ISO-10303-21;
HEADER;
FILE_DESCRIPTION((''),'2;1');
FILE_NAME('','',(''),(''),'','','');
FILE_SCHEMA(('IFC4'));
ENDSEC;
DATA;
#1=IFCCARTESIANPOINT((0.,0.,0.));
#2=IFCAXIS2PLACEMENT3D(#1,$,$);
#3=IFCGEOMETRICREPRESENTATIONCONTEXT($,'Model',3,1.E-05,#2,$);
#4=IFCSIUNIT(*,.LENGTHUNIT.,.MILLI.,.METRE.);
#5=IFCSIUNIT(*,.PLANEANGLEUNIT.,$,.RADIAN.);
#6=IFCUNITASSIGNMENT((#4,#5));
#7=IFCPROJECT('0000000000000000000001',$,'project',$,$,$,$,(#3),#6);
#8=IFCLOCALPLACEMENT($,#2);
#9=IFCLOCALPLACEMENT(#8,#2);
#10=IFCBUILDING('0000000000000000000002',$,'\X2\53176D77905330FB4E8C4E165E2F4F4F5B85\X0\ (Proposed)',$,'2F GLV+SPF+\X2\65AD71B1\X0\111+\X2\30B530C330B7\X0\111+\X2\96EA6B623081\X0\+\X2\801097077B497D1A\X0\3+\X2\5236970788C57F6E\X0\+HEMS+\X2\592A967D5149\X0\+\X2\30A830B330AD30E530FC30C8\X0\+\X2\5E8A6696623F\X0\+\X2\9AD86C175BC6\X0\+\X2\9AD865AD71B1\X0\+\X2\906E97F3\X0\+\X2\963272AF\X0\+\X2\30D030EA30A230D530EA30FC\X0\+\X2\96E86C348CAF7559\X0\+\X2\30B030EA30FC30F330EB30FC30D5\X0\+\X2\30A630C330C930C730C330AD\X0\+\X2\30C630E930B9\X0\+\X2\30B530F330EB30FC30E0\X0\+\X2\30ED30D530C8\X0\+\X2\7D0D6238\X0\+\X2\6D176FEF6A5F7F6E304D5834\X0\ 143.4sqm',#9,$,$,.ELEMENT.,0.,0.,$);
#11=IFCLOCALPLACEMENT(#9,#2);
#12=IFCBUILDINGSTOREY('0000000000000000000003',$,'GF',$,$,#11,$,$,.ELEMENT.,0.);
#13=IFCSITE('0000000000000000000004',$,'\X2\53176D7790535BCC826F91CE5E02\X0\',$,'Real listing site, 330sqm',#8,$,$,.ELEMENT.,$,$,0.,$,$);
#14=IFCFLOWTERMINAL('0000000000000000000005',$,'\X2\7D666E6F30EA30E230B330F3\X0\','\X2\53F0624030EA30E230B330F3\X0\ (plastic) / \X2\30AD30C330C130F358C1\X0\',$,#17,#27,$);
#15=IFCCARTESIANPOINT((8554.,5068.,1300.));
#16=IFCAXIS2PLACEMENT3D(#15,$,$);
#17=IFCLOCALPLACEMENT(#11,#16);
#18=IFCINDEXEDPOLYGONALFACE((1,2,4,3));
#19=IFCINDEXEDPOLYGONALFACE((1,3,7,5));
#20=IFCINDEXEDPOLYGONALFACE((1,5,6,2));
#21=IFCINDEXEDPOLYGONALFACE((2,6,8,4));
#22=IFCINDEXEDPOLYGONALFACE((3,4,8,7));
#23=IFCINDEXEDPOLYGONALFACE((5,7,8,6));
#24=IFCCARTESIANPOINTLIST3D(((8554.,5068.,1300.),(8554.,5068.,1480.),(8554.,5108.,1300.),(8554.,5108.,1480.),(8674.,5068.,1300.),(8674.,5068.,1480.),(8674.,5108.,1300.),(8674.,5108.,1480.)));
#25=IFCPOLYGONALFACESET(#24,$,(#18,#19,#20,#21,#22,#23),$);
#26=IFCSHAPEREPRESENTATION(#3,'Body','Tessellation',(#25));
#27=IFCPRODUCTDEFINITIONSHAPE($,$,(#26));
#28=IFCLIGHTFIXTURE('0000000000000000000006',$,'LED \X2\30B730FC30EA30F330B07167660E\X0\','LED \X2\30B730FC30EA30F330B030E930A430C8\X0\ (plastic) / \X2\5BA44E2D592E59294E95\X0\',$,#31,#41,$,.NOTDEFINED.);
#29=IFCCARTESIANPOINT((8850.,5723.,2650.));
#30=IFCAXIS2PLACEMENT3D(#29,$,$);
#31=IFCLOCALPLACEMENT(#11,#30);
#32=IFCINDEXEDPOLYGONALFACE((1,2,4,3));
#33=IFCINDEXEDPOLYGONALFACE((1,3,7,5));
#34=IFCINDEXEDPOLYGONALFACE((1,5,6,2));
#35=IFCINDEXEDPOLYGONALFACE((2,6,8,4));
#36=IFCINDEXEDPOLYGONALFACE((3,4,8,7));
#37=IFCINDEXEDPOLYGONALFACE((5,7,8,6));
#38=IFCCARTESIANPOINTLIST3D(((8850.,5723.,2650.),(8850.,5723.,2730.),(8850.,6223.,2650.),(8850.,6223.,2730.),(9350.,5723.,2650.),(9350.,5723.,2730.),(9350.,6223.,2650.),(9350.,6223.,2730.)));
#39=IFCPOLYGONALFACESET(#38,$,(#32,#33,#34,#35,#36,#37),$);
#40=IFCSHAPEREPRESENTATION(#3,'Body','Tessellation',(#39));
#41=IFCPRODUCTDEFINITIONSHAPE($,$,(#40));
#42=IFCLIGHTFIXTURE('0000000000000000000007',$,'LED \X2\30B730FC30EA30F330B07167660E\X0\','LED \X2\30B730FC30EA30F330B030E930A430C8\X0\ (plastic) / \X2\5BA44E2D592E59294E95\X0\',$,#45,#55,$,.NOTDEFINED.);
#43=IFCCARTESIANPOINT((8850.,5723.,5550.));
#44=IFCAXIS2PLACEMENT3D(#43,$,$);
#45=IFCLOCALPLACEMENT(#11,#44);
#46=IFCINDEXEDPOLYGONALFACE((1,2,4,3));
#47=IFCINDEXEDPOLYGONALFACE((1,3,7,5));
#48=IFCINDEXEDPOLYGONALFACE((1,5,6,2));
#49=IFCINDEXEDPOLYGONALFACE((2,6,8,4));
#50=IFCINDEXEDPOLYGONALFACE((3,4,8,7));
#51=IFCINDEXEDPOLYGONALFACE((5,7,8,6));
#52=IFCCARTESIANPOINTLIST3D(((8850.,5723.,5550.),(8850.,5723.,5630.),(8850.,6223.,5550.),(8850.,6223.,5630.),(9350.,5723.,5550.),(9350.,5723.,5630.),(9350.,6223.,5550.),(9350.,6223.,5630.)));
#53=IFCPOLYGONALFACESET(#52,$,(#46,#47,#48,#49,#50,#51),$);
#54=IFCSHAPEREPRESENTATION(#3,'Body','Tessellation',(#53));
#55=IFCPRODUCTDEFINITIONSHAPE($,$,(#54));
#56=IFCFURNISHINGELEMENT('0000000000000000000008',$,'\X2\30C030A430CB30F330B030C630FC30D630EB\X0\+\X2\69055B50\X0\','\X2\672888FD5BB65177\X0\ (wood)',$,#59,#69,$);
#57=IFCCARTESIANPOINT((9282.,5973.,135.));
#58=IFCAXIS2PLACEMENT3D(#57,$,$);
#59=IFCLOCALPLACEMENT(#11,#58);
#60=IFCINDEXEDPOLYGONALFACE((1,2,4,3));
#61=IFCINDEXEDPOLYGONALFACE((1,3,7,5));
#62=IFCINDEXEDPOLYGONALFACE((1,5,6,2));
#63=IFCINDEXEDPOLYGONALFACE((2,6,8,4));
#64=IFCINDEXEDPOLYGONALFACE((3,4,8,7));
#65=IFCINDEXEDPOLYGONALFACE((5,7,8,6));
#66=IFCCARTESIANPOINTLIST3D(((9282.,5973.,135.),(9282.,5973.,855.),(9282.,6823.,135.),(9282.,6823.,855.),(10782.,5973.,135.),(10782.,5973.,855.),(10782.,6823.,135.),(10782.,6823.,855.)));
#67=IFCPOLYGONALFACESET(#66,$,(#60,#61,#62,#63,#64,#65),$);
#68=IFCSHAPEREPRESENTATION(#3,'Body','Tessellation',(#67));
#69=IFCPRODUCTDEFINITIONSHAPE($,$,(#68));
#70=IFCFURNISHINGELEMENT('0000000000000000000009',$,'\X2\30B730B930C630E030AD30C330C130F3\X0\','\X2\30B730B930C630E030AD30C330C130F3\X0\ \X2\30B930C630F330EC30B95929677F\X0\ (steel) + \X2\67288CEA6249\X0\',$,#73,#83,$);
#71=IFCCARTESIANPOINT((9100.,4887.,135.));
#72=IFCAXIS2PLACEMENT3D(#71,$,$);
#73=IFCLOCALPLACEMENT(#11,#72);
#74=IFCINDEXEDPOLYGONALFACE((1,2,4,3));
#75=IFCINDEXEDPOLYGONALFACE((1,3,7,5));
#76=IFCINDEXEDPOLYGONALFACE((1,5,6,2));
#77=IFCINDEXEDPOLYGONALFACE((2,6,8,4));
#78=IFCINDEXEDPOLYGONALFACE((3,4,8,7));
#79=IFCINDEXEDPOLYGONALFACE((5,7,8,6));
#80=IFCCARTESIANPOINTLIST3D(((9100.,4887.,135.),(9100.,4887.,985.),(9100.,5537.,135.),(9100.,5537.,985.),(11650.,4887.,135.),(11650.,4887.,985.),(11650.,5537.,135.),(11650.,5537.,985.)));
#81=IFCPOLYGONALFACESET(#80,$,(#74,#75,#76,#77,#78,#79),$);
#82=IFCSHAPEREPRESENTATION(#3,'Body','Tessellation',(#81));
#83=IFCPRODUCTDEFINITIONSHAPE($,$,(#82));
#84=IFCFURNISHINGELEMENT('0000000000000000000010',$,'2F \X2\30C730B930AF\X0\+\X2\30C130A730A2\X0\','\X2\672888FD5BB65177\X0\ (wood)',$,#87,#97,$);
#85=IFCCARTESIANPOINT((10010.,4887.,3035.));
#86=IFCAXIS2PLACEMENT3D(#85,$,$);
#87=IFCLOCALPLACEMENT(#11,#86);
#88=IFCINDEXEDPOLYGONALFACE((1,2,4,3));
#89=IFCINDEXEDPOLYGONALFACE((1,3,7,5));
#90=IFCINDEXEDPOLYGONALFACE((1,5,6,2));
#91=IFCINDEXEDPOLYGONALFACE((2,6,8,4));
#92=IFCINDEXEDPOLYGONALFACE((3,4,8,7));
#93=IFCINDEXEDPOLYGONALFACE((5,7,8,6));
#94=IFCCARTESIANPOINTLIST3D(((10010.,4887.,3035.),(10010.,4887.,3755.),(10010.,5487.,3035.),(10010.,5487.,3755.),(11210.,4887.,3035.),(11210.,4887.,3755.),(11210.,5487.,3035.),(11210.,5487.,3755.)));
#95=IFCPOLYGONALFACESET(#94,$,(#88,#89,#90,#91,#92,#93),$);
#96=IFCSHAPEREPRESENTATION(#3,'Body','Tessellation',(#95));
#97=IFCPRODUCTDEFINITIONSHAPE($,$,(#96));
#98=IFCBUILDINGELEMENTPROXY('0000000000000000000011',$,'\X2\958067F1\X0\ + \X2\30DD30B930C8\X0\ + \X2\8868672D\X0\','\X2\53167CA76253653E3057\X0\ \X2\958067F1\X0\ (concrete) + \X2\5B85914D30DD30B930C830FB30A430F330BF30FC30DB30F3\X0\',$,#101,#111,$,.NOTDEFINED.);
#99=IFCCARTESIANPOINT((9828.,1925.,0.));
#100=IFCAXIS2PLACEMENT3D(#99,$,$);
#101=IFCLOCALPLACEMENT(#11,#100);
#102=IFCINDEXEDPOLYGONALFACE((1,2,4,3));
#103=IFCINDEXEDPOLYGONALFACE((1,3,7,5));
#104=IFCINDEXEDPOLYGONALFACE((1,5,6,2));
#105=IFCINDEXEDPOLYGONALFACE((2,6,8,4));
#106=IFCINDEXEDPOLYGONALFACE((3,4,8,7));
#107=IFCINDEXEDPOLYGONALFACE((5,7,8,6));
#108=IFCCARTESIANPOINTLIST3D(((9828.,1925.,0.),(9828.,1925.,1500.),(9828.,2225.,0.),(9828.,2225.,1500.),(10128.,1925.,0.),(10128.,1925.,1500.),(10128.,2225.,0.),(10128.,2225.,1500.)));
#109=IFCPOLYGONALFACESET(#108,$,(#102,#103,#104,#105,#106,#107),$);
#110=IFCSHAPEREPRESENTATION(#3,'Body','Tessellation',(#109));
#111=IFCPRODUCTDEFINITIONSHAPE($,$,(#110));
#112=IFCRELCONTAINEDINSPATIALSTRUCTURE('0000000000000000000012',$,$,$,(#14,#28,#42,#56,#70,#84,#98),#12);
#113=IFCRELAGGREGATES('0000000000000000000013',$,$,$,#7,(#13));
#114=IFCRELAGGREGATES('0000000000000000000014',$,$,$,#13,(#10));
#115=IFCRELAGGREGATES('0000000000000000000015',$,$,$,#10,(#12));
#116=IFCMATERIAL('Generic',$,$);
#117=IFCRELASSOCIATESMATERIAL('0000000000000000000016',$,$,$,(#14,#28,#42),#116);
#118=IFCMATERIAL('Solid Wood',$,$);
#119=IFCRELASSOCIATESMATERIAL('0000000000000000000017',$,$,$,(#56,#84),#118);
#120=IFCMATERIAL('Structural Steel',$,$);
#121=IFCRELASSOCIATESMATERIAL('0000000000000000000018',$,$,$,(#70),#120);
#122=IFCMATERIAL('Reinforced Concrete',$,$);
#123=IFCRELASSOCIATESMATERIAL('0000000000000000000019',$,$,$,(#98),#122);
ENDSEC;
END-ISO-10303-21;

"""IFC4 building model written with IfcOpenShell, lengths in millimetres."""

from ifc_helpers import new_model, si_unit, frame, frame_2d, origin, place, context, project, spatial, rectangle, extrude, material, element, save


model = new_model("IFC4")

# Units and contexts
model_context = context("Model", 3, precision=1e-05, world=origin())
ifc_project = project(units=[si_unit("LENGTHUNIT", "METRE", prefix="MILLI"), si_unit("PLANEANGLEUNIT", "RADIAN")], contexts=[model_context])

# Site, building, storey
site_placement = place(None, origin())
site = spatial("IfcSite", under=ifc_project, at=site_placement, Name="北海道富良野市", ObjectType="Real listing site, 330sqm", CompositionType="ELEMENT", RefElevation=0.0)
building_placement = place(site_placement, origin())
building = spatial("IfcBuilding", under=site, at=building_placement, Name="北海道・二世帯住宅 (Proposed)", ObjectType="2F GLV+SPF+断熱111+サッシ111+雪止め+耐震等級3+制震装置+HEMS+太陽光+エコキュート+床暖房+高気密+高断熱+遮音+防犯+バリアフリー+雨水貯留+グリーンルーフ+ウッドデッキ+テラス+サンルーム+ロフト+納戸+洗濯機置き場 143.4sqm", CompositionType="ELEMENT", ElevationOfRefHeight=0.0, ElevationOfTerrain=0.0)
storey_placement = place(building_placement, origin())
storey = spatial("IfcBuildingStorey", under=building, at=storey_placement, Name="GF", CompositionType="ELEMENT", Elevation=0.0)

# Shared definitions
ifc_material_1 = material(Name="Solid Wood")

# Shared definitions
ifc_material_2 = material(Name="Structural Steel")

# Shared definitions
ifc_material_3 = material(Name="Reinforced Concrete")

# Flow terminal
ifc_material_4 = material(Name="Generic")
flow_terminal_1_placement = place(storey_placement, frame((8554.0, 5068.0, 1300.0)))
element("IfcFlowTerminal", 1, at=flow_terminal_1_placement, inside=storey, material=ifc_material_4, Name="給湯リモコン", Description="台所リモコン (plastic) / キッチン壁", context=model_context, shape_type="SweptSolid", body=[
    extrude(rectangle(XDim=120.0, YDim=40.0, at=frame_2d((60.0, 20.0))), frame((8554.0, 5068.0, 1300.0)), (0.0, 0.0, 1.0), 180.0),
])

# Light fixtures
light_fixture_1_placement = place(storey_placement, frame((8850.0, 5723.0, 2650.0)))
element("IfcLightFixture", 2, at=light_fixture_1_placement, inside=storey, material=ifc_material_4, Name="LED シーリング照明", Description="LED シーリングライト (plastic) / 室中央天井", PredefinedType="NOTDEFINED", context=model_context, shape_type="SweptSolid", body=[
    extrude(rectangle(XDim=500.0, YDim=500.0, at=frame_2d((250.0, 250.0))), frame((8850.0, 5723.0, 2650.0)), (0.0, 0.0, 1.0), 80.0),
])
light_fixture_2_placement = place(storey_placement, frame((8850.0, 5723.0, 5550.0)))
element("IfcLightFixture", 3, at=light_fixture_2_placement, inside=storey, material=ifc_material_4, Name="LED シーリング照明", Description="LED シーリングライト (plastic) / 室中央天井", PredefinedType="NOTDEFINED", context=model_context, shape_type="SweptSolid", body=[
    extrude(rectangle(XDim=500.0, YDim=500.0, at=frame_2d((250.0, 250.0))), frame((8850.0, 5723.0, 5550.0)), (0.0, 0.0, 1.0), 80.0),
])

# Furnishing elements
furnishing_1_placement = place(storey_placement, frame((9282.0, 5973.0, 135.0)))
element("IfcFurnishingElement", 4, at=furnishing_1_placement, inside=storey, material=ifc_material_1, Name="ダイニングテーブル+椅子", Description="木製家具 (wood)", context=model_context, shape_type="SweptSolid", body=[
    extrude(rectangle(XDim=1500.0, YDim=850.0, at=frame_2d((750.0, 425.0))), frame((9282.0, 5973.0, 135.0)), (0.0, 0.0, 1.0), 720.0),
])
furnishing_2_placement = place(storey_placement, frame((9100.0, 4887.0, 135.0)))
element("IfcFurnishingElement", 5, at=furnishing_2_placement, inside=storey, material=ifc_material_2, Name="システムキッチン", Description="システムキッチン ステンレス天板 (steel) + 木質扉", context=model_context, shape_type="SweptSolid", body=[
    extrude(rectangle(XDim=2550.0, YDim=650.0, at=frame_2d((1275.0, 325.0))), frame((9100.0, 4887.0, 135.0)), (0.0, 0.0, 1.0), 850.0),
])
furnishing_3_placement = place(storey_placement, frame((10010.0, 4887.0, 3035.0)))
element("IfcFurnishingElement", 6, at=furnishing_3_placement, inside=storey, material=ifc_material_1, Name="2F デスク+チェア", Description="木製家具 (wood)", context=model_context, shape_type="SweptSolid", body=[
    extrude(rectangle(XDim=1200.0, YDim=600.0, at=frame_2d((600.0, 300.0))), frame((10010.0, 4887.0, 3035.0)), (0.0, 0.0, 1.0), 720.0),
])

# Building element proxy
proxy_placement = place(storey_placement, frame((9828.0, 1925.0, 0.0)))
element("IfcBuildingElementProxy", 7, at=proxy_placement, inside=storey, material=ifc_material_3, Name="門柱 + ポスト + 表札", Description="化粧打放し 門柱 (concrete) + 宅配ポスト・インターホン", PredefinedType="NOTDEFINED", context=model_context, shape_type="SweptSolid", body=[
    extrude(rectangle(XDim=300.0, YDim=300.0, at=frame_2d((150.0, 150.0))), frame((9828.0, 1925.0, 0.0)), (0.0, 0.0, 1.0), 1500.0),
])

save(model, "model.ifc")
